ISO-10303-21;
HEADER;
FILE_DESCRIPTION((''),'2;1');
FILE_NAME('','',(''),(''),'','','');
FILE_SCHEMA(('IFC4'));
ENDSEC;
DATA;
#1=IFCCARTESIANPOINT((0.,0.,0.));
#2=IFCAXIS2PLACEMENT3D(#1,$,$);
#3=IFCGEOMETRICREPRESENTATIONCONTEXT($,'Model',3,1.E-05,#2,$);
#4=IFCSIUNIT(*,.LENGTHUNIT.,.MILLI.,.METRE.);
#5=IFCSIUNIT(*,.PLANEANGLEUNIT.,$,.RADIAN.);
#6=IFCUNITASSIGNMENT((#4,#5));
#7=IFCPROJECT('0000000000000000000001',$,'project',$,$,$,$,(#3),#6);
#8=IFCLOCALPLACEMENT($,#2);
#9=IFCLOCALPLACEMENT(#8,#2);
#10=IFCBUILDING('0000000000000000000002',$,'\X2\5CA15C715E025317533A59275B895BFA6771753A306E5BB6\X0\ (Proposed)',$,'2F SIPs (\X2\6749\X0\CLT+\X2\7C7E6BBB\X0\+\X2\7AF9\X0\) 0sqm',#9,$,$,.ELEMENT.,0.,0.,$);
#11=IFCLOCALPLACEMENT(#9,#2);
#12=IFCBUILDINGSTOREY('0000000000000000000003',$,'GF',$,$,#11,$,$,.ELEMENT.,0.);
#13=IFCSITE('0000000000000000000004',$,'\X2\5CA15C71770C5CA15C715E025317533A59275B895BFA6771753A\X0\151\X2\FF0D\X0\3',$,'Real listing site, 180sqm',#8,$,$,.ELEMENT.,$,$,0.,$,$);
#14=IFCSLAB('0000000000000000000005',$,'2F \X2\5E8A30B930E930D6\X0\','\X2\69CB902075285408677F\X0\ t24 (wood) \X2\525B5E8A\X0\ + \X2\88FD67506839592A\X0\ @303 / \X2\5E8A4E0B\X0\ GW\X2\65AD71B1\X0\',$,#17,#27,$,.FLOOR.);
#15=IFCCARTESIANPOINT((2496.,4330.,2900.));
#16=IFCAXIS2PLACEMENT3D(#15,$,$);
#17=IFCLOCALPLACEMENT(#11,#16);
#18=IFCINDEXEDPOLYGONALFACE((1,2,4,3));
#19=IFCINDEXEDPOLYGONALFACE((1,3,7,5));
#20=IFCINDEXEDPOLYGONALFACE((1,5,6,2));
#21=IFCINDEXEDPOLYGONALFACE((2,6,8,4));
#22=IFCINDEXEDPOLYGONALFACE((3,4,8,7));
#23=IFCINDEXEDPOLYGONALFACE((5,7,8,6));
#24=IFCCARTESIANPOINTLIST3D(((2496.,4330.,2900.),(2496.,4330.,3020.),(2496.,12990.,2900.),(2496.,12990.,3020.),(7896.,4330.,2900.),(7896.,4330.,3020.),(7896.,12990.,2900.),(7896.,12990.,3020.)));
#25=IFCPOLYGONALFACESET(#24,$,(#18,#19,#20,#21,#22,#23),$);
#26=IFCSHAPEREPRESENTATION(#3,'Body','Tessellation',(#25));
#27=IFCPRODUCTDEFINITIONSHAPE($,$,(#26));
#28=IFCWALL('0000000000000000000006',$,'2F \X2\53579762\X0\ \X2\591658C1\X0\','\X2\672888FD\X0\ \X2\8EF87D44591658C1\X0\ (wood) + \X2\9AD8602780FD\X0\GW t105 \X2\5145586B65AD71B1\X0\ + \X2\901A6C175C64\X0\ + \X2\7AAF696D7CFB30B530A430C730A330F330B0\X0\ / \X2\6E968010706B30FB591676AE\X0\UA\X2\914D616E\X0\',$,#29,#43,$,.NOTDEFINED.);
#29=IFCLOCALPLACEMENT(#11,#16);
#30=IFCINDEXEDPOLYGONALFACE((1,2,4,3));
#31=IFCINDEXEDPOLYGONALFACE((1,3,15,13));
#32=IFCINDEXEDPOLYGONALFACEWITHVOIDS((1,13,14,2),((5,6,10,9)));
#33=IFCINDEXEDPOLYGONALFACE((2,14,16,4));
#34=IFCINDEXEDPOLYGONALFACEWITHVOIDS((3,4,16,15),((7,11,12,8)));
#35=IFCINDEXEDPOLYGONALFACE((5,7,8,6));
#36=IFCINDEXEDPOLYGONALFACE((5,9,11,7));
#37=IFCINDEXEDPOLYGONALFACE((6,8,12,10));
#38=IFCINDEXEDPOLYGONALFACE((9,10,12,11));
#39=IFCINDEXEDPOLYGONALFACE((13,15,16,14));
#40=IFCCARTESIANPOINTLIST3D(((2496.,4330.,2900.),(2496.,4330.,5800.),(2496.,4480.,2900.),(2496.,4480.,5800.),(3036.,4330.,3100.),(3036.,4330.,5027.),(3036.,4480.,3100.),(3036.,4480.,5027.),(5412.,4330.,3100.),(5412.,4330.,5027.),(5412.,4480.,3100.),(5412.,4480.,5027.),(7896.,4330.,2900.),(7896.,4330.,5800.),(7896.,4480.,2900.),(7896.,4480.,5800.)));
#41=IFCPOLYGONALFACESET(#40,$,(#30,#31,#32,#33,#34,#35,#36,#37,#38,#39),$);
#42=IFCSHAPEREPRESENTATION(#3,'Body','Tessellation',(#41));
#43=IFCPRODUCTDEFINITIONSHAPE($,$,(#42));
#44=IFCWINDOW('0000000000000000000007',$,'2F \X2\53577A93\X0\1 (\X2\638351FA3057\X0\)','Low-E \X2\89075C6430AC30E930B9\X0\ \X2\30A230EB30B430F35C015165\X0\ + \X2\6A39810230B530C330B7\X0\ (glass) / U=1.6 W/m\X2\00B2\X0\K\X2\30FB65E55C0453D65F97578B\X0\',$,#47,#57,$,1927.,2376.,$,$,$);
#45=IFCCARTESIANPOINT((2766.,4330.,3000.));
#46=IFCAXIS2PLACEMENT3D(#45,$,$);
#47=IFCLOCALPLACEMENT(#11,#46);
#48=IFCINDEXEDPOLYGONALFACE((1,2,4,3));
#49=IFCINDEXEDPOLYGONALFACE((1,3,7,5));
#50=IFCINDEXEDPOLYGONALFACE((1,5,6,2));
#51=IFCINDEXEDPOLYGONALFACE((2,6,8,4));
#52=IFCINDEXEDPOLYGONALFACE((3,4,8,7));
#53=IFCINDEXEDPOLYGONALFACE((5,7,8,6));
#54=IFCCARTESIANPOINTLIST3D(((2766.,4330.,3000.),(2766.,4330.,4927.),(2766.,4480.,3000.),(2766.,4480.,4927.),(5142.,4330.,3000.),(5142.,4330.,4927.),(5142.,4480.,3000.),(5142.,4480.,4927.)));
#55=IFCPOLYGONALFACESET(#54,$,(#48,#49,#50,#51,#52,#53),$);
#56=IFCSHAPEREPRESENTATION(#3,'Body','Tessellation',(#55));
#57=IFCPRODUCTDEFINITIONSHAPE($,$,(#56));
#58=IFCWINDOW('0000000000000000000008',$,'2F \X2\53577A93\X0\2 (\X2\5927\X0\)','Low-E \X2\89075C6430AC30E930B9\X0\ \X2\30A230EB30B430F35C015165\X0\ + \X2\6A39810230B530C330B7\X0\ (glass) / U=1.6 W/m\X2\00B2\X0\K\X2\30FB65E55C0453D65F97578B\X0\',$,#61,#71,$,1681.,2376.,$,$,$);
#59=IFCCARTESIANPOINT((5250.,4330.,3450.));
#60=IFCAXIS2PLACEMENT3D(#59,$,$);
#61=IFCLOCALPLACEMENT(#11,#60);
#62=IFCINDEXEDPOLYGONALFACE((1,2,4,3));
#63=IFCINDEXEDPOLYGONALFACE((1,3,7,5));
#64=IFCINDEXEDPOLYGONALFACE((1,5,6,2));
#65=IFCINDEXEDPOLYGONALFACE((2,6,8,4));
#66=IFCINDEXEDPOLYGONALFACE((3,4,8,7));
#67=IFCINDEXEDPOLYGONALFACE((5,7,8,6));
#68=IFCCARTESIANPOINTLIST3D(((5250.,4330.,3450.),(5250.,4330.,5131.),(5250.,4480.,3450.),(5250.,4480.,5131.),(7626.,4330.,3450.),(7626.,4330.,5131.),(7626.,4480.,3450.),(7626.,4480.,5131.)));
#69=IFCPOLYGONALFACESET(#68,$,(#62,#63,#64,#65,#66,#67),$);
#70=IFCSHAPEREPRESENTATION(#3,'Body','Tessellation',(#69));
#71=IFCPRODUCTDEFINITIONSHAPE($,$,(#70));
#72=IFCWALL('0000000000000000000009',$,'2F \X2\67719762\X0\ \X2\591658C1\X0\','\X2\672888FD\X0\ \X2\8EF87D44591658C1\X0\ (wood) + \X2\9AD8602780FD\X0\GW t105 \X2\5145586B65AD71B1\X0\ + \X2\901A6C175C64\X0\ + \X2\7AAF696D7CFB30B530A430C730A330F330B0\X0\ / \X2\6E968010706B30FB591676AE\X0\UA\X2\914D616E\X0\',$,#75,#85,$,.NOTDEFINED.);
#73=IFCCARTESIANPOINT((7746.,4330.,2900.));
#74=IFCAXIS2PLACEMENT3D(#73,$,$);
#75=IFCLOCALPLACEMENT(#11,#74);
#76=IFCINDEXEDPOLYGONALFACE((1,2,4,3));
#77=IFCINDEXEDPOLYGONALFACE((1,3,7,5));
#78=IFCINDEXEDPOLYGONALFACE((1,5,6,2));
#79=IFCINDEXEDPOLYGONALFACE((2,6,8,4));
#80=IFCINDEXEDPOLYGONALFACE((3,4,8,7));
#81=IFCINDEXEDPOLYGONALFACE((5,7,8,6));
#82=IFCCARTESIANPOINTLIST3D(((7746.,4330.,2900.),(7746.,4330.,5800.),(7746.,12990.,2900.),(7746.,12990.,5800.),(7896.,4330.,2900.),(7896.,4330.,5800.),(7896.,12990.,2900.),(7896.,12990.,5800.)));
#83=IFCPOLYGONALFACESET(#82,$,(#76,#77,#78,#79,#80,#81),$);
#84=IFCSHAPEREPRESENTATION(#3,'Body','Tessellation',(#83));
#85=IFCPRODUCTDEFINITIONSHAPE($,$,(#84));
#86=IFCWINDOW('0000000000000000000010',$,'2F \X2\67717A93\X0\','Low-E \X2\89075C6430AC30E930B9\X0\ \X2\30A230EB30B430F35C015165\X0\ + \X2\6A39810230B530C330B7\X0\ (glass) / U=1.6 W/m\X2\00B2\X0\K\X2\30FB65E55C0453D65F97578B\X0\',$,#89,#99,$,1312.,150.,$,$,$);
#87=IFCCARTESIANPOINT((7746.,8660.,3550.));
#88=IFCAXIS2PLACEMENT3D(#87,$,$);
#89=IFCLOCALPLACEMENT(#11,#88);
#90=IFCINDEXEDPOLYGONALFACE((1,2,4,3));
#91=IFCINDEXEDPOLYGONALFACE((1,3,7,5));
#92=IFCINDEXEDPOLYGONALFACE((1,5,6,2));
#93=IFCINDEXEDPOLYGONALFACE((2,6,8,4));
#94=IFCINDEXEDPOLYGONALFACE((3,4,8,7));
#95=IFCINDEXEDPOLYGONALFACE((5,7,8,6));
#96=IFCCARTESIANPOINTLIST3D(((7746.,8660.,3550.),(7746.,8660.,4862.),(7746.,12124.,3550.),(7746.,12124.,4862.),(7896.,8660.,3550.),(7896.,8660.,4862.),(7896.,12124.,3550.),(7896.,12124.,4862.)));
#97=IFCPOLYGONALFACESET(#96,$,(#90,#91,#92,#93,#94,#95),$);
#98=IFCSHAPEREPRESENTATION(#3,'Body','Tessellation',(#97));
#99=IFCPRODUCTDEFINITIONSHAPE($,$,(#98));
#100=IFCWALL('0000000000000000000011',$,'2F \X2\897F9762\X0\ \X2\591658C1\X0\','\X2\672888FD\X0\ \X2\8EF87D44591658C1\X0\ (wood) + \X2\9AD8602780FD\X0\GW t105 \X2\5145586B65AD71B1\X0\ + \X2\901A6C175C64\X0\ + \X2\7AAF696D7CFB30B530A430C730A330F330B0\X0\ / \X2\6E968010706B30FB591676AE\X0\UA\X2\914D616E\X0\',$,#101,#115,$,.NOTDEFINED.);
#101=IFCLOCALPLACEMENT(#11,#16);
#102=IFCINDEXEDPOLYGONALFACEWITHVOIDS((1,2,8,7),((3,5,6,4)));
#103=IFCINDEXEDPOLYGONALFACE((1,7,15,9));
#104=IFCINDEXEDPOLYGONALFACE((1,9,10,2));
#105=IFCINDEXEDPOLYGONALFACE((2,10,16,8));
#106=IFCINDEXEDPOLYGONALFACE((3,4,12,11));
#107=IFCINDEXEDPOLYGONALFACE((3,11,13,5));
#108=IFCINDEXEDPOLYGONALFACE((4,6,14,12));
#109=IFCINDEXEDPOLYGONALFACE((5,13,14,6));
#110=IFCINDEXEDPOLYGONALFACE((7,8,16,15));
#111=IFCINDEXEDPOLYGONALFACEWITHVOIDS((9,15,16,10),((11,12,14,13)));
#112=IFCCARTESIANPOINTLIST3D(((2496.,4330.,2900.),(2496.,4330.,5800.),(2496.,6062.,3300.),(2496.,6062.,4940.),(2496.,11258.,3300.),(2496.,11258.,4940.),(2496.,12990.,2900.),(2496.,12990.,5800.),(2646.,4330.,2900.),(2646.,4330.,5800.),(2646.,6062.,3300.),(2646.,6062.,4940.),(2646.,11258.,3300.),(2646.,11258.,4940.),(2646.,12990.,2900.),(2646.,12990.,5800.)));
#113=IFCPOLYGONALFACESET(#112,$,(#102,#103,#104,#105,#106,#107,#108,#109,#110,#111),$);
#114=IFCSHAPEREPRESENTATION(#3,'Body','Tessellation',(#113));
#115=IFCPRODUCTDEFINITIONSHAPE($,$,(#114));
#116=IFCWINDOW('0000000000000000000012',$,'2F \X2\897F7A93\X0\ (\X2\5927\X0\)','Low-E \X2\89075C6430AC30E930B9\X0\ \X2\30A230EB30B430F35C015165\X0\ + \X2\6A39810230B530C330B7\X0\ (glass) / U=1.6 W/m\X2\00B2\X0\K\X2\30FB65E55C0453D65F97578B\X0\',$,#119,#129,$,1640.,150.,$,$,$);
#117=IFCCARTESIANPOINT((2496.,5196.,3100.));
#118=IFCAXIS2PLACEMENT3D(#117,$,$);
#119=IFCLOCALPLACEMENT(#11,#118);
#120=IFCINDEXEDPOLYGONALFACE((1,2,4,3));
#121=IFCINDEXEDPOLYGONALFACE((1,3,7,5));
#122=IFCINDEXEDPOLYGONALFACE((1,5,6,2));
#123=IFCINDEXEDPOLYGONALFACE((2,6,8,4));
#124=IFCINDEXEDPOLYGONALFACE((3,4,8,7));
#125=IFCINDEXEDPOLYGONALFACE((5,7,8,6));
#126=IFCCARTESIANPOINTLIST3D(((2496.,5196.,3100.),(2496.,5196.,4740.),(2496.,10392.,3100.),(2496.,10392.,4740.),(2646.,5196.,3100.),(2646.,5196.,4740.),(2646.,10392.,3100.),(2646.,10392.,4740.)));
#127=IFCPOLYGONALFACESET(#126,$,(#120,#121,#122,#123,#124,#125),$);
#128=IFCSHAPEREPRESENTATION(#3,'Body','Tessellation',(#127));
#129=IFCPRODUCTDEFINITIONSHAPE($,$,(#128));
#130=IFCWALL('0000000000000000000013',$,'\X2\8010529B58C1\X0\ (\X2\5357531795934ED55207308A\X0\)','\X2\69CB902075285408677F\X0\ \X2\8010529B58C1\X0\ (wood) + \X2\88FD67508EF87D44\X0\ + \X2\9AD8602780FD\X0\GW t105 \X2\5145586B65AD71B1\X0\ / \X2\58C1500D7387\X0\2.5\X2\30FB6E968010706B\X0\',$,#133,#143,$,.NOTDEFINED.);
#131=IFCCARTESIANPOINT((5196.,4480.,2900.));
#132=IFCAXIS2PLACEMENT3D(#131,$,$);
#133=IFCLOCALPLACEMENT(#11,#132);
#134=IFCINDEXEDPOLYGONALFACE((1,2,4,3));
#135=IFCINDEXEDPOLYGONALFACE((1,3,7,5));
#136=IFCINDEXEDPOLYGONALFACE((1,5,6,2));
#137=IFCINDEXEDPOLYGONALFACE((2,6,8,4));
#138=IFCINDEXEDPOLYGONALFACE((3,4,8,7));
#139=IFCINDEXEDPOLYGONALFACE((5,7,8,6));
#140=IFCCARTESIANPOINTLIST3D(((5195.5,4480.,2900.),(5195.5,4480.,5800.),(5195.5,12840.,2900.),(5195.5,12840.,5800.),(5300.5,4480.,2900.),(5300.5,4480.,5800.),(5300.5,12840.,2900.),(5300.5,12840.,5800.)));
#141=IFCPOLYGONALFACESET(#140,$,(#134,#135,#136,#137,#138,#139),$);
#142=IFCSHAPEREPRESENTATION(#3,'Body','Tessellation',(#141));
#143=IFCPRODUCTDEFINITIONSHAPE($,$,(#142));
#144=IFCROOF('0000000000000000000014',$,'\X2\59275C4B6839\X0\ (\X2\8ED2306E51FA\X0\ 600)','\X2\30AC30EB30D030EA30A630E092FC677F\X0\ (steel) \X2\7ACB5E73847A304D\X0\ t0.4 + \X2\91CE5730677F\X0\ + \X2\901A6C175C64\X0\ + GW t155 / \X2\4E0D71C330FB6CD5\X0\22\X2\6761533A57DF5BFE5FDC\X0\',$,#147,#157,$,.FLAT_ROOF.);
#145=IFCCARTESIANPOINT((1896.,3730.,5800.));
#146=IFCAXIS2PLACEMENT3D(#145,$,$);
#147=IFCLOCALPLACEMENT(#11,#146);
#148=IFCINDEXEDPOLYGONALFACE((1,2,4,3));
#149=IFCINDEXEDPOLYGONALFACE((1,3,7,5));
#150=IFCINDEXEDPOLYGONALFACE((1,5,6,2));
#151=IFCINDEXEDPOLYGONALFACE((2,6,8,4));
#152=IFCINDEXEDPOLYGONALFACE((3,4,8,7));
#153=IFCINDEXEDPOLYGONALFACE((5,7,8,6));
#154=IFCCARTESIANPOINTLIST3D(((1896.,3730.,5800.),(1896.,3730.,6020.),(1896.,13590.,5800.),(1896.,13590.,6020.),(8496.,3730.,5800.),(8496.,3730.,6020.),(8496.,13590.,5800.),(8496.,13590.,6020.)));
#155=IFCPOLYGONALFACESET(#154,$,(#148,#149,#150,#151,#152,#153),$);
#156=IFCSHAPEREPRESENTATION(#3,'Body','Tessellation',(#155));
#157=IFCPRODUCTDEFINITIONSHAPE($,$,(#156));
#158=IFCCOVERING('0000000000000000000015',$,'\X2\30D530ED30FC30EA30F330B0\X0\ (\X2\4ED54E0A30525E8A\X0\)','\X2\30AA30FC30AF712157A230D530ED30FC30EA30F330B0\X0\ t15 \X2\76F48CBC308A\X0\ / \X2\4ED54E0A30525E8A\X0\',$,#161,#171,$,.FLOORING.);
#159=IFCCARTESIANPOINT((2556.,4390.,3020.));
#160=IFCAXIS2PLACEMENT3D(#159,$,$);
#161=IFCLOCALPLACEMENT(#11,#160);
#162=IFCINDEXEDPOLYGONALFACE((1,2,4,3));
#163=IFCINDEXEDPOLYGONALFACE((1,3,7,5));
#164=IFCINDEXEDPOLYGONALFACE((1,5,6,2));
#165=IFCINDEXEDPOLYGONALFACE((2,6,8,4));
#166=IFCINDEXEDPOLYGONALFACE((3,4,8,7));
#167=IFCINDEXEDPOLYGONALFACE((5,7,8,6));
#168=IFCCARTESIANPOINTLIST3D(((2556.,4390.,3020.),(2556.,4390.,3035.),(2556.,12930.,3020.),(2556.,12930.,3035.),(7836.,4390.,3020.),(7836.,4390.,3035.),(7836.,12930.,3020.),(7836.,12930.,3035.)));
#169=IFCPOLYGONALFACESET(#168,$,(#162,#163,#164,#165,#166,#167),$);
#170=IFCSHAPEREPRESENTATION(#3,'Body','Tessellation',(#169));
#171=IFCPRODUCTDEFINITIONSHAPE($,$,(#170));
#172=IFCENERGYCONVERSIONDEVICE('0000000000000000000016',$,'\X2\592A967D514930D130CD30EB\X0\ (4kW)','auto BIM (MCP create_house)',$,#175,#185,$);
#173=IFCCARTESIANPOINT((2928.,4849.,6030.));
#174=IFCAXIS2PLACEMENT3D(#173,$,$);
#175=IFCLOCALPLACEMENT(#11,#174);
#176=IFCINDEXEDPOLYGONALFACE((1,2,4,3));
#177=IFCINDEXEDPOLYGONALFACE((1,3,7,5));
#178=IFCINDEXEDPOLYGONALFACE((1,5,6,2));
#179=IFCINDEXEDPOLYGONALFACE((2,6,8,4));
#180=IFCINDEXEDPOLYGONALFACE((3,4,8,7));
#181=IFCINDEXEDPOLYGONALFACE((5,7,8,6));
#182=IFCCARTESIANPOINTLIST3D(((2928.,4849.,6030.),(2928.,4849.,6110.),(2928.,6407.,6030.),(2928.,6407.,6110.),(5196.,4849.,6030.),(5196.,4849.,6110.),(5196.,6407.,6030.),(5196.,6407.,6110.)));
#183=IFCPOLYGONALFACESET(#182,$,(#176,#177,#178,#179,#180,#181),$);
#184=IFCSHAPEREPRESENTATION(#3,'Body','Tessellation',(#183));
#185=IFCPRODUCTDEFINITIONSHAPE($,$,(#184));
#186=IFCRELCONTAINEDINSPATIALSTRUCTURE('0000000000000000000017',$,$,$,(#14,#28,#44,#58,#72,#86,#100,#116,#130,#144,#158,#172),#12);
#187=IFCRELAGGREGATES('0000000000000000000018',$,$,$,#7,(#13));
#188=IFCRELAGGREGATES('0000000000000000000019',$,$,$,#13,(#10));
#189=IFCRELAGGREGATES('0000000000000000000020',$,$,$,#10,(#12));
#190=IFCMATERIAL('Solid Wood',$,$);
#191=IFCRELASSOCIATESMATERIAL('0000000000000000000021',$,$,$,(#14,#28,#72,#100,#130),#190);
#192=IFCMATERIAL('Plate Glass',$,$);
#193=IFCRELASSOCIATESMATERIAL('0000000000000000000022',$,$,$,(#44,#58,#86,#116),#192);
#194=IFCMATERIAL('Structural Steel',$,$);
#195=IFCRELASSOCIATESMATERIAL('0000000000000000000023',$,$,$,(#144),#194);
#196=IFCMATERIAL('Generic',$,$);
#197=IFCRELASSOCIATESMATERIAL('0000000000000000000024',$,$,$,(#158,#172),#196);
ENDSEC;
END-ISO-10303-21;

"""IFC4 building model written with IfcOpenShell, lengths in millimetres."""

from ifc_helpers import new_model, si_unit, frame, frame_2d, origin, place, context, project, spatial, rectangle, extrude, material, element, fill, save


model = new_model("IFC4")

# Units and contexts
model_context = context("Model", 3, precision=1e-05, world=origin())
ifc_project = project(units=[si_unit("LENGTHUNIT", "METRE", prefix="MILLI"), si_unit("PLANEANGLEUNIT", "RADIAN")], contexts=[model_context])

# Site, building, storey
site_placement = place(None, origin())
site = spatial("IfcSite", under=ifc_project, at=site_placement, Name="岡山県岡山市北区大安寺東町151－3", ObjectType="Real listing site, 180sqm", CompositionType="ELEMENT", RefElevation=0.0)
building_placement = place(site_placement, origin())
building = spatial("IfcBuilding", under=site, at=building_placement, Name="岡山市北区大安寺東町の家 (Proposed)", ObjectType="2F SIPs (杉CLT+籾殻+竹) 0sqm", CompositionType="ELEMENT", ElevationOfRefHeight=0.0, ElevationOfTerrain=0.0)
storey_placement = place(building_placement, origin())
storey = spatial("IfcBuildingStorey", under=building, at=storey_placement, Name="GF", CompositionType="ELEMENT", Elevation=0.0)

# Slab
ifc_material_1 = material(Name="Solid Wood")
slab_placement = place(storey_placement, frame((2496.0, 4330.0, 2900.0)))
element("IfcSlab", 1, at=slab_placement, inside=storey, material=ifc_material_1, Name="2F 床スラブ", Description="構造用合板 t24 (wood) 剛床 + 製材根太 @303 / 床下 GW断熱", PredefinedType="FLOOR", context=model_context, shape_type="SweptSolid", body=[
    extrude(rectangle(XDim=5400.0, YDim=8660.0, at=frame_2d((2700.0, 4330.0))), frame((2496.0, 4330.0, 2900.0)), (0.0, 0.0, 1.0), 120.0),
])

# Wall, openings, windows
wall_1_placement = place(storey_placement, frame((2496.0, 4330.0, 2900.0)))
wall_1 = element("IfcWall", 2, at=wall_1_placement, inside=storey, material=ifc_material_1, Name="2F 南面 外壁", Description="木製 軸組外壁 (wood) + 高性能GW t105 充填断熱 + 通気層 + 窯業系サイディング / 準耐火・外皮UA配慮", PredefinedType="NOTDEFINED", context=model_context, shape_type="SweptSolid", body=[
    extrude(rectangle(XDim=5400.0, YDim=150.0, at=frame_2d((2700.0, 75.0))), frame((2496.0, 4330.0, 2900.0)), (0.0, 0.0, 1.0), 2900.0),
])
opening_1_placement = place(storey_placement, frame((2766.0, 4330.0, 3000.0)))
opening_1 = element("IfcOpeningElement", 3, at=opening_1_placement, cuts=wall_1, PredefinedType="NOTDEFINED", context=model_context, shape_type="SweptSolid", body=[
    extrude(rectangle(XDim=2376.0, YDim=150.0, at=frame_2d((1188.0, 75.0))), frame((2766.0, 4330.0, 3000.0)), (0.0, 0.0, 1.0), 1927.0),
])
opening_2_placement = place(storey_placement, frame((5250.0, 4330.0, 3450.0)))
opening_2 = element("IfcOpeningElement", 4, at=opening_2_placement, cuts=wall_1, PredefinedType="NOTDEFINED", context=model_context, shape_type="SweptSolid", body=[
    extrude(rectangle(XDim=2376.0, YDim=150.0, at=frame_2d((1188.0, 75.0))), frame((5250.0, 4330.0, 3450.0)), (0.0, 0.0, 1.0), 1681.0),
])
ifc_material_2 = material(Name="Plate Glass")
window_1_placement = place(storey_placement, frame((2766.0, 4330.0, 3000.0)))
window_1 = element("IfcWindow", 5, at=window_1_placement, inside=storey, material=ifc_material_2, Name="2F 南窓1 (掃出し)", Description="Low-E 複層ガラス アルゴン封入 + 樹脂サッシ (glass) / U=1.6 W/m²K・日射取得型", OverallHeight=1927.0, OverallWidth=2376.0, context=model_context, shape_type="SweptSolid", body=[
    extrude(rectangle(XDim=2376.0, YDim=150.0, at=frame_2d((1188.0, 75.0))), frame((2766.0, 4330.0, 3000.0)), (0.0, 0.0, 1.0), 1927.0),
])
fill(opening_1, window_1)
window_2_placement = place(storey_placement, frame((5250.0, 4330.0, 3450.0)))
window_2 = element("IfcWindow", 6, at=window_2_placement, inside=storey, material=ifc_material_2, Name="2F 南窓2 (大)", Description="Low-E 複層ガラス アルゴン封入 + 樹脂サッシ (glass) / U=1.6 W/m²K・日射取得型", OverallHeight=1681.0, OverallWidth=2376.0, context=model_context, shape_type="SweptSolid", body=[
    extrude(rectangle(XDim=2376.0, YDim=150.0, at=frame_2d((1188.0, 75.0))), frame((5250.0, 4330.0, 3450.0)), (0.0, 0.0, 1.0), 1681.0),
])
fill(opening_2, window_2)

# Walls, openings, windows
wall_2_placement = place(storey_placement, frame((7746.0, 4330.0, 2900.0)))
wall_2 = element("IfcWall", 7, at=wall_2_placement, inside=storey, material=ifc_material_1, Name="2F 東面 外壁", Description="木製 軸組外壁 (wood) + 高性能GW t105 充填断熱 + 通気層 + 窯業系サイディング / 準耐火・外皮UA配慮", PredefinedType="NOTDEFINED", context=model_context, shape_type="SweptSolid", body=[
    extrude(rectangle(XDim=150.0, YDim=8660.0, at=frame_2d((75.0, 4330.0))), frame((7746.0, 4330.0, 2900.0)), (0.0, 0.0, 1.0), 2900.0),
])
opening_3_placement = place(storey_placement, frame((7746.0, 8660.0, 3550.0)))
opening_3 = element("IfcOpeningElement", 8, at=opening_3_placement, cuts=wall_2, PredefinedType="NOTDEFINED", context=model_context, shape_type="SweptSolid", body=[
    extrude(rectangle(XDim=150.0, YDim=3464.0, at=frame_2d((75.0, 1732.0))), frame((7746.0, 8660.0, 3550.0)), (0.0, 0.0, 1.0), 1312.0),
])
window_3_placement = place(storey_placement, frame((7746.0, 8660.0, 3550.0)))
window_3 = element("IfcWindow", 9, at=window_3_placement, inside=storey, material=ifc_material_2, Name="2F 東窓", Description="Low-E 複層ガラス アルゴン封入 + 樹脂サッシ (glass) / U=1.6 W/m²K・日射取得型", OverallHeight=1312.0, OverallWidth=150.0, context=model_context, shape_type="SweptSolid", body=[
    extrude(rectangle(XDim=150.0, YDim=3464.0, at=frame_2d((75.0, 1732.0))), frame((7746.0, 8660.0, 3550.0)), (0.0, 0.0, 1.0), 1312.0),
])
fill(opening_3, window_3)
wall_3_placement = place(storey_placement, frame((2496.0, 4330.0, 2900.0)))
wall_3 = element("IfcWall", 10, at=wall_3_placement, inside=storey, material=ifc_material_1, Name="2F 西面 外壁", Description="木製 軸組外壁 (wood) + 高性能GW t105 充填断熱 + 通気層 + 窯業系サイディング / 準耐火・外皮UA配慮", PredefinedType="NOTDEFINED", context=model_context, shape_type="SweptSolid", body=[
    extrude(rectangle(XDim=150.0, YDim=8660.0, at=frame_2d((75.0, 4330.0))), frame((2496.0, 4330.0, 2900.0)), (0.0, 0.0, 1.0), 2900.0),
])
opening_4_placement = place(storey_placement, frame((2496.0, 5196.0, 3100.0)))
opening_4 = element("IfcOpeningElement", 11, at=opening_4_placement, cuts=wall_3, PredefinedType="NOTDEFINED", context=model_context, shape_type="SweptSolid", body=[
    extrude(rectangle(XDim=150.0, YDim=5196.0, at=frame_2d((75.0, 2598.0))), frame((2496.0, 5196.0, 3100.0)), (0.0, 0.0, 1.0), 1640.0),
])
window_4_placement = place(storey_placement, frame((2496.0, 5196.0, 3100.0)))
window_4 = element("IfcWindow", 12, at=window_4_placement, inside=storey, material=ifc_material_2, Name="2F 西窓 (大)", Description="Low-E 複層ガラス アルゴン封入 + 樹脂サッシ (glass) / U=1.6 W/m²K・日射取得型", OverallHeight=1640.0, OverallWidth=150.0, context=model_context, shape_type="SweptSolid", body=[
    extrude(rectangle(XDim=150.0, YDim=5196.0, at=frame_2d((75.0, 2598.0))), frame((2496.0, 5196.0, 3100.0)), (0.0, 0.0, 1.0), 1640.0),
])
fill(opening_4, window_4)

# Wall
wall_4_placement = place(storey_placement, frame((5196.0, 4480.0, 2900.0)))
element("IfcWall", 13, at=wall_4_placement, inside=storey, material=ifc_material_1, Name="耐力壁 (南北間仕切り)", Description="構造用合板 耐力壁 (wood) + 製材軸組 + 高性能GW t105 充填断熱 / 壁倍率2.5・準耐火", PredefinedType="NOTDEFINED", context=model_context, shape_type="SweptSolid", body=[
    extrude(rectangle(XDim=105.0, YDim=8360.0, at=frame_2d((52.0, 4180.0))), frame((5196.0, 4480.0, 2900.0)), (0.0, 0.0, 1.0), 2900.0),
])

# Roof
ifc_material_3 = material(Name="Structural Steel")
roof_placement = place(storey_placement, frame((1896.0, 3730.0, 5800.0)))
element("IfcRoof", 14, at=roof_placement, inside=storey, material=ifc_material_3, Name="大屋根 (軒の出 600)", Description="ガルバリウム鋼板 (steel) 立平葺き t0.4 + 野地板 + 通気層 + GW t155 / 不燃・法22条区域対応", PredefinedType="FLAT_ROOF", context=model_context, shape_type="SweptSolid", body=[
    extrude(rectangle(XDim=6600.0, YDim=9860.0, at=frame_2d((3300.0, 4930.0))), frame((1896.0, 3730.0, 5800.0)), (0.0, 0.0, 1.0), 220.0),
])

# Covering
ifc_material_4 = material(Name="Generic")
covering_placement = place(storey_placement, frame((2556.0, 4390.0, 3020.0)))
element("IfcCovering", 15, at=covering_placement, inside=storey, material=ifc_material_4, Name="フローリング (仕上げ床)", Description="オーク無垢フローリング t15 直貼り / 仕上げ床", PredefinedType="FLOORING", context=model_context, shape_type="SweptSolid", body=[
    extrude(rectangle(XDim=5280.0, YDim=8540.0, at=frame_2d((2640.0, 4270.0))), frame((2556.0, 4390.0, 3020.0)), (0.0, 0.0, 1.0), 15.0),
])

# Energy conversion device
energy_conversion_device_placement = place(storey_placement, frame((2928.0, 4849.0, 6030.0)))
element("IfcEnergyConversionDevice", 16, at=energy_conversion_device_placement, inside=storey, material=ifc_material_4, Name="太陽光パネル (4kW)", Description="auto BIM (MCP create_house)", context=model_context, shape_type="SweptSolid", body=[
    extrude(rectangle(XDim=2268.0, YDim=1558.0, at=frame_2d((1134.0, 779.0))), frame((2928.0, 4849.0, 6030.0)), (0.0, 0.0, 1.0), 80.0),
])

save(model, "model.ifc")
